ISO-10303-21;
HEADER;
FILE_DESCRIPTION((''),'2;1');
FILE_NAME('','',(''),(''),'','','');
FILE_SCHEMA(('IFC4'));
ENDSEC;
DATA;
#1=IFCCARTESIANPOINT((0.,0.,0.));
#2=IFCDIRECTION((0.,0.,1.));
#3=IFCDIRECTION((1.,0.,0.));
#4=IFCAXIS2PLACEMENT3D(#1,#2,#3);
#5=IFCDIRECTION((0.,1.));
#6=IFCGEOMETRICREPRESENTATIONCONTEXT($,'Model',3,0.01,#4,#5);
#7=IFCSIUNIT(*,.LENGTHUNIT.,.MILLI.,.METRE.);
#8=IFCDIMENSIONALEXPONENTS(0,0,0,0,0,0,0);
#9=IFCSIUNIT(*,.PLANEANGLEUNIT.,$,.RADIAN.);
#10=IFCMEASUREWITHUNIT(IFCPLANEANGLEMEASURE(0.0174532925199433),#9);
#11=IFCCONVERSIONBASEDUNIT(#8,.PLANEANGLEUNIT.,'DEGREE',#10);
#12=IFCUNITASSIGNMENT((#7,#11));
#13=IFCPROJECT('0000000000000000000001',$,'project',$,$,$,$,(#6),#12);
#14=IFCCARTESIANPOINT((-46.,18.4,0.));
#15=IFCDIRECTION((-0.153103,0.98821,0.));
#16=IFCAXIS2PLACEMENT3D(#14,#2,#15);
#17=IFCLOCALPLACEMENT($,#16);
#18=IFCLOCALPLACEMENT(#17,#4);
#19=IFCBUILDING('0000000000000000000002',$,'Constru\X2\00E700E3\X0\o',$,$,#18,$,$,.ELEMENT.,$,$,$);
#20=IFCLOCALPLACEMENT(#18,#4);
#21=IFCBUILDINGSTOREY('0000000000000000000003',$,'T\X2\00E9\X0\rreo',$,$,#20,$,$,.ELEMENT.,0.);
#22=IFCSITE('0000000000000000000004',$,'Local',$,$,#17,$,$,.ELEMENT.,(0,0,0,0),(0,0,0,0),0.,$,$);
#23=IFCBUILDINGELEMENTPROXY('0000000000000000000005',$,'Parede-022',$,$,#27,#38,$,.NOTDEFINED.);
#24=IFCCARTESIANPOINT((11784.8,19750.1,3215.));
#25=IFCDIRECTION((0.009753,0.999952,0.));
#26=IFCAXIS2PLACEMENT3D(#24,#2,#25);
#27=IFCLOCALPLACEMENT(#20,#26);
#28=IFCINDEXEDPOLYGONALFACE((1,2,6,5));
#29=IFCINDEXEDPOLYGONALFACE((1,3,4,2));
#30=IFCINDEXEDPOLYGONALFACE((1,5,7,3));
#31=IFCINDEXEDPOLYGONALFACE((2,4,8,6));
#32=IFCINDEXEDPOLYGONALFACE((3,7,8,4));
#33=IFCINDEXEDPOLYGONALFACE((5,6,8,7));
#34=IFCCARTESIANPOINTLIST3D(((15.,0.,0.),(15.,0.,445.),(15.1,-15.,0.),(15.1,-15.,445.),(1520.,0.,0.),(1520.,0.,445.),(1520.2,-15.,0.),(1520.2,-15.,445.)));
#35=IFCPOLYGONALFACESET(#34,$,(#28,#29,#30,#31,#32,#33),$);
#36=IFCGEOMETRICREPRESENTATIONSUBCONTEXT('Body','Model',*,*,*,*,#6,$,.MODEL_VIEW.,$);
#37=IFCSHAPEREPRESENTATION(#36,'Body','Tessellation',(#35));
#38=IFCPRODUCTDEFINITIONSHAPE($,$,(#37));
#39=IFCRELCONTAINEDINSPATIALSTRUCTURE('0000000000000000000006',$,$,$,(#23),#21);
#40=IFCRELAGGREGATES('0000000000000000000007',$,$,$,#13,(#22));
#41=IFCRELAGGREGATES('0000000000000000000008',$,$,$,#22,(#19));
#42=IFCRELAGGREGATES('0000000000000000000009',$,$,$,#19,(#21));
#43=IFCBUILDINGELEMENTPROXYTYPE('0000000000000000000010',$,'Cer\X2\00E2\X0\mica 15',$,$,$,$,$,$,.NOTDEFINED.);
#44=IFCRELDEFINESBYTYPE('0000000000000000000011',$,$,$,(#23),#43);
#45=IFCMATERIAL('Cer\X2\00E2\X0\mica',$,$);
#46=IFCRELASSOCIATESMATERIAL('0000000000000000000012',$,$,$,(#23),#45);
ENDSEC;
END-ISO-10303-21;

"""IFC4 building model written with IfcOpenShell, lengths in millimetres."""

from ifc_helpers import new_model, entity, si_unit, converted_unit, direction, frame, origin_with_axes, place, context, subcontext, project, spatial, line, indexed_curve, outline, extrude, material, type_object, element, save


model = new_model("IFC4")

# Units and contexts
model_context = context("Model", 3, precision=0.01, world=origin_with_axes(), true_north=direction((0.0, 1.0)))
body_context = subcontext(model_context, "Body", "Model", "MODEL_VIEW")
ifc_project = project(units=[si_unit("LENGTHUNIT", "METRE", prefix="MILLI"), converted_unit("PLANEANGLEUNIT", "DEGREE", entity("IfcPlaneAngleMeasure", 0.0174532925199433), si_unit("PLANEANGLEUNIT", "RADIAN"), dimensions=[0, 0, 0, 0, 0, 0, 0])], contexts=[model_context])

# Site, building, storey
site_placement = place(None, frame((-46.0, 18.4, 0.0), z_axis=(0.0, 0.0, 1.0), x_axis=(-0.153103, 0.98821, 0.0)))
site = spatial("IfcSite", under=ifc_project, at=site_placement, Name="Local", CompositionType="ELEMENT", RefLatitude=(0, 0, 0, 0), RefLongitude=(0, 0, 0, 0), RefElevation=0.0)
building_placement = place(site_placement, origin_with_axes())
building = spatial("IfcBuilding", under=site, at=building_placement, Name="Construção", CompositionType="ELEMENT")
storey_placement = place(building_placement, origin_with_axes())
storey = spatial("IfcBuildingStorey", under=building, at=storey_placement, Name="Térreo", CompositionType="ELEMENT", Elevation=0.0)

# Building element proxy
ifc_material_1 = material(Name="Cerâmica")
building_element_proxy_type_1 = type_object("IfcBuildingElementProxyType", Name="Cerâmica 15", PredefinedType="NOTDEFINED")
proxy_1_placement = place(storey_placement, frame((11784.8, 19750.1, 3215.0), z_axis=(0.0, 0.0, 1.0), x_axis=(0.009753, 0.999952, 0.0)))
element("IfcBuildingElementProxy", 1, at=proxy_1_placement, inside=storey, type_object=building_element_proxy_type_1, material=ifc_material_1, Name="Parede-022", PredefinedType="NOTDEFINED", context=body_context, shape_type="SweptSolid", body=[
    extrude(outline(indexed_curve([(15.1, -15.0), (1520.2, -15.0), (1520.0, 0.0), (15.0, 0.0)], segments=[line(1, 2, 3, 4, 1)])), origin_with_axes(), (0.0, 0.0, 1.0), 445.0),
])

save(model, "model.ifc")
